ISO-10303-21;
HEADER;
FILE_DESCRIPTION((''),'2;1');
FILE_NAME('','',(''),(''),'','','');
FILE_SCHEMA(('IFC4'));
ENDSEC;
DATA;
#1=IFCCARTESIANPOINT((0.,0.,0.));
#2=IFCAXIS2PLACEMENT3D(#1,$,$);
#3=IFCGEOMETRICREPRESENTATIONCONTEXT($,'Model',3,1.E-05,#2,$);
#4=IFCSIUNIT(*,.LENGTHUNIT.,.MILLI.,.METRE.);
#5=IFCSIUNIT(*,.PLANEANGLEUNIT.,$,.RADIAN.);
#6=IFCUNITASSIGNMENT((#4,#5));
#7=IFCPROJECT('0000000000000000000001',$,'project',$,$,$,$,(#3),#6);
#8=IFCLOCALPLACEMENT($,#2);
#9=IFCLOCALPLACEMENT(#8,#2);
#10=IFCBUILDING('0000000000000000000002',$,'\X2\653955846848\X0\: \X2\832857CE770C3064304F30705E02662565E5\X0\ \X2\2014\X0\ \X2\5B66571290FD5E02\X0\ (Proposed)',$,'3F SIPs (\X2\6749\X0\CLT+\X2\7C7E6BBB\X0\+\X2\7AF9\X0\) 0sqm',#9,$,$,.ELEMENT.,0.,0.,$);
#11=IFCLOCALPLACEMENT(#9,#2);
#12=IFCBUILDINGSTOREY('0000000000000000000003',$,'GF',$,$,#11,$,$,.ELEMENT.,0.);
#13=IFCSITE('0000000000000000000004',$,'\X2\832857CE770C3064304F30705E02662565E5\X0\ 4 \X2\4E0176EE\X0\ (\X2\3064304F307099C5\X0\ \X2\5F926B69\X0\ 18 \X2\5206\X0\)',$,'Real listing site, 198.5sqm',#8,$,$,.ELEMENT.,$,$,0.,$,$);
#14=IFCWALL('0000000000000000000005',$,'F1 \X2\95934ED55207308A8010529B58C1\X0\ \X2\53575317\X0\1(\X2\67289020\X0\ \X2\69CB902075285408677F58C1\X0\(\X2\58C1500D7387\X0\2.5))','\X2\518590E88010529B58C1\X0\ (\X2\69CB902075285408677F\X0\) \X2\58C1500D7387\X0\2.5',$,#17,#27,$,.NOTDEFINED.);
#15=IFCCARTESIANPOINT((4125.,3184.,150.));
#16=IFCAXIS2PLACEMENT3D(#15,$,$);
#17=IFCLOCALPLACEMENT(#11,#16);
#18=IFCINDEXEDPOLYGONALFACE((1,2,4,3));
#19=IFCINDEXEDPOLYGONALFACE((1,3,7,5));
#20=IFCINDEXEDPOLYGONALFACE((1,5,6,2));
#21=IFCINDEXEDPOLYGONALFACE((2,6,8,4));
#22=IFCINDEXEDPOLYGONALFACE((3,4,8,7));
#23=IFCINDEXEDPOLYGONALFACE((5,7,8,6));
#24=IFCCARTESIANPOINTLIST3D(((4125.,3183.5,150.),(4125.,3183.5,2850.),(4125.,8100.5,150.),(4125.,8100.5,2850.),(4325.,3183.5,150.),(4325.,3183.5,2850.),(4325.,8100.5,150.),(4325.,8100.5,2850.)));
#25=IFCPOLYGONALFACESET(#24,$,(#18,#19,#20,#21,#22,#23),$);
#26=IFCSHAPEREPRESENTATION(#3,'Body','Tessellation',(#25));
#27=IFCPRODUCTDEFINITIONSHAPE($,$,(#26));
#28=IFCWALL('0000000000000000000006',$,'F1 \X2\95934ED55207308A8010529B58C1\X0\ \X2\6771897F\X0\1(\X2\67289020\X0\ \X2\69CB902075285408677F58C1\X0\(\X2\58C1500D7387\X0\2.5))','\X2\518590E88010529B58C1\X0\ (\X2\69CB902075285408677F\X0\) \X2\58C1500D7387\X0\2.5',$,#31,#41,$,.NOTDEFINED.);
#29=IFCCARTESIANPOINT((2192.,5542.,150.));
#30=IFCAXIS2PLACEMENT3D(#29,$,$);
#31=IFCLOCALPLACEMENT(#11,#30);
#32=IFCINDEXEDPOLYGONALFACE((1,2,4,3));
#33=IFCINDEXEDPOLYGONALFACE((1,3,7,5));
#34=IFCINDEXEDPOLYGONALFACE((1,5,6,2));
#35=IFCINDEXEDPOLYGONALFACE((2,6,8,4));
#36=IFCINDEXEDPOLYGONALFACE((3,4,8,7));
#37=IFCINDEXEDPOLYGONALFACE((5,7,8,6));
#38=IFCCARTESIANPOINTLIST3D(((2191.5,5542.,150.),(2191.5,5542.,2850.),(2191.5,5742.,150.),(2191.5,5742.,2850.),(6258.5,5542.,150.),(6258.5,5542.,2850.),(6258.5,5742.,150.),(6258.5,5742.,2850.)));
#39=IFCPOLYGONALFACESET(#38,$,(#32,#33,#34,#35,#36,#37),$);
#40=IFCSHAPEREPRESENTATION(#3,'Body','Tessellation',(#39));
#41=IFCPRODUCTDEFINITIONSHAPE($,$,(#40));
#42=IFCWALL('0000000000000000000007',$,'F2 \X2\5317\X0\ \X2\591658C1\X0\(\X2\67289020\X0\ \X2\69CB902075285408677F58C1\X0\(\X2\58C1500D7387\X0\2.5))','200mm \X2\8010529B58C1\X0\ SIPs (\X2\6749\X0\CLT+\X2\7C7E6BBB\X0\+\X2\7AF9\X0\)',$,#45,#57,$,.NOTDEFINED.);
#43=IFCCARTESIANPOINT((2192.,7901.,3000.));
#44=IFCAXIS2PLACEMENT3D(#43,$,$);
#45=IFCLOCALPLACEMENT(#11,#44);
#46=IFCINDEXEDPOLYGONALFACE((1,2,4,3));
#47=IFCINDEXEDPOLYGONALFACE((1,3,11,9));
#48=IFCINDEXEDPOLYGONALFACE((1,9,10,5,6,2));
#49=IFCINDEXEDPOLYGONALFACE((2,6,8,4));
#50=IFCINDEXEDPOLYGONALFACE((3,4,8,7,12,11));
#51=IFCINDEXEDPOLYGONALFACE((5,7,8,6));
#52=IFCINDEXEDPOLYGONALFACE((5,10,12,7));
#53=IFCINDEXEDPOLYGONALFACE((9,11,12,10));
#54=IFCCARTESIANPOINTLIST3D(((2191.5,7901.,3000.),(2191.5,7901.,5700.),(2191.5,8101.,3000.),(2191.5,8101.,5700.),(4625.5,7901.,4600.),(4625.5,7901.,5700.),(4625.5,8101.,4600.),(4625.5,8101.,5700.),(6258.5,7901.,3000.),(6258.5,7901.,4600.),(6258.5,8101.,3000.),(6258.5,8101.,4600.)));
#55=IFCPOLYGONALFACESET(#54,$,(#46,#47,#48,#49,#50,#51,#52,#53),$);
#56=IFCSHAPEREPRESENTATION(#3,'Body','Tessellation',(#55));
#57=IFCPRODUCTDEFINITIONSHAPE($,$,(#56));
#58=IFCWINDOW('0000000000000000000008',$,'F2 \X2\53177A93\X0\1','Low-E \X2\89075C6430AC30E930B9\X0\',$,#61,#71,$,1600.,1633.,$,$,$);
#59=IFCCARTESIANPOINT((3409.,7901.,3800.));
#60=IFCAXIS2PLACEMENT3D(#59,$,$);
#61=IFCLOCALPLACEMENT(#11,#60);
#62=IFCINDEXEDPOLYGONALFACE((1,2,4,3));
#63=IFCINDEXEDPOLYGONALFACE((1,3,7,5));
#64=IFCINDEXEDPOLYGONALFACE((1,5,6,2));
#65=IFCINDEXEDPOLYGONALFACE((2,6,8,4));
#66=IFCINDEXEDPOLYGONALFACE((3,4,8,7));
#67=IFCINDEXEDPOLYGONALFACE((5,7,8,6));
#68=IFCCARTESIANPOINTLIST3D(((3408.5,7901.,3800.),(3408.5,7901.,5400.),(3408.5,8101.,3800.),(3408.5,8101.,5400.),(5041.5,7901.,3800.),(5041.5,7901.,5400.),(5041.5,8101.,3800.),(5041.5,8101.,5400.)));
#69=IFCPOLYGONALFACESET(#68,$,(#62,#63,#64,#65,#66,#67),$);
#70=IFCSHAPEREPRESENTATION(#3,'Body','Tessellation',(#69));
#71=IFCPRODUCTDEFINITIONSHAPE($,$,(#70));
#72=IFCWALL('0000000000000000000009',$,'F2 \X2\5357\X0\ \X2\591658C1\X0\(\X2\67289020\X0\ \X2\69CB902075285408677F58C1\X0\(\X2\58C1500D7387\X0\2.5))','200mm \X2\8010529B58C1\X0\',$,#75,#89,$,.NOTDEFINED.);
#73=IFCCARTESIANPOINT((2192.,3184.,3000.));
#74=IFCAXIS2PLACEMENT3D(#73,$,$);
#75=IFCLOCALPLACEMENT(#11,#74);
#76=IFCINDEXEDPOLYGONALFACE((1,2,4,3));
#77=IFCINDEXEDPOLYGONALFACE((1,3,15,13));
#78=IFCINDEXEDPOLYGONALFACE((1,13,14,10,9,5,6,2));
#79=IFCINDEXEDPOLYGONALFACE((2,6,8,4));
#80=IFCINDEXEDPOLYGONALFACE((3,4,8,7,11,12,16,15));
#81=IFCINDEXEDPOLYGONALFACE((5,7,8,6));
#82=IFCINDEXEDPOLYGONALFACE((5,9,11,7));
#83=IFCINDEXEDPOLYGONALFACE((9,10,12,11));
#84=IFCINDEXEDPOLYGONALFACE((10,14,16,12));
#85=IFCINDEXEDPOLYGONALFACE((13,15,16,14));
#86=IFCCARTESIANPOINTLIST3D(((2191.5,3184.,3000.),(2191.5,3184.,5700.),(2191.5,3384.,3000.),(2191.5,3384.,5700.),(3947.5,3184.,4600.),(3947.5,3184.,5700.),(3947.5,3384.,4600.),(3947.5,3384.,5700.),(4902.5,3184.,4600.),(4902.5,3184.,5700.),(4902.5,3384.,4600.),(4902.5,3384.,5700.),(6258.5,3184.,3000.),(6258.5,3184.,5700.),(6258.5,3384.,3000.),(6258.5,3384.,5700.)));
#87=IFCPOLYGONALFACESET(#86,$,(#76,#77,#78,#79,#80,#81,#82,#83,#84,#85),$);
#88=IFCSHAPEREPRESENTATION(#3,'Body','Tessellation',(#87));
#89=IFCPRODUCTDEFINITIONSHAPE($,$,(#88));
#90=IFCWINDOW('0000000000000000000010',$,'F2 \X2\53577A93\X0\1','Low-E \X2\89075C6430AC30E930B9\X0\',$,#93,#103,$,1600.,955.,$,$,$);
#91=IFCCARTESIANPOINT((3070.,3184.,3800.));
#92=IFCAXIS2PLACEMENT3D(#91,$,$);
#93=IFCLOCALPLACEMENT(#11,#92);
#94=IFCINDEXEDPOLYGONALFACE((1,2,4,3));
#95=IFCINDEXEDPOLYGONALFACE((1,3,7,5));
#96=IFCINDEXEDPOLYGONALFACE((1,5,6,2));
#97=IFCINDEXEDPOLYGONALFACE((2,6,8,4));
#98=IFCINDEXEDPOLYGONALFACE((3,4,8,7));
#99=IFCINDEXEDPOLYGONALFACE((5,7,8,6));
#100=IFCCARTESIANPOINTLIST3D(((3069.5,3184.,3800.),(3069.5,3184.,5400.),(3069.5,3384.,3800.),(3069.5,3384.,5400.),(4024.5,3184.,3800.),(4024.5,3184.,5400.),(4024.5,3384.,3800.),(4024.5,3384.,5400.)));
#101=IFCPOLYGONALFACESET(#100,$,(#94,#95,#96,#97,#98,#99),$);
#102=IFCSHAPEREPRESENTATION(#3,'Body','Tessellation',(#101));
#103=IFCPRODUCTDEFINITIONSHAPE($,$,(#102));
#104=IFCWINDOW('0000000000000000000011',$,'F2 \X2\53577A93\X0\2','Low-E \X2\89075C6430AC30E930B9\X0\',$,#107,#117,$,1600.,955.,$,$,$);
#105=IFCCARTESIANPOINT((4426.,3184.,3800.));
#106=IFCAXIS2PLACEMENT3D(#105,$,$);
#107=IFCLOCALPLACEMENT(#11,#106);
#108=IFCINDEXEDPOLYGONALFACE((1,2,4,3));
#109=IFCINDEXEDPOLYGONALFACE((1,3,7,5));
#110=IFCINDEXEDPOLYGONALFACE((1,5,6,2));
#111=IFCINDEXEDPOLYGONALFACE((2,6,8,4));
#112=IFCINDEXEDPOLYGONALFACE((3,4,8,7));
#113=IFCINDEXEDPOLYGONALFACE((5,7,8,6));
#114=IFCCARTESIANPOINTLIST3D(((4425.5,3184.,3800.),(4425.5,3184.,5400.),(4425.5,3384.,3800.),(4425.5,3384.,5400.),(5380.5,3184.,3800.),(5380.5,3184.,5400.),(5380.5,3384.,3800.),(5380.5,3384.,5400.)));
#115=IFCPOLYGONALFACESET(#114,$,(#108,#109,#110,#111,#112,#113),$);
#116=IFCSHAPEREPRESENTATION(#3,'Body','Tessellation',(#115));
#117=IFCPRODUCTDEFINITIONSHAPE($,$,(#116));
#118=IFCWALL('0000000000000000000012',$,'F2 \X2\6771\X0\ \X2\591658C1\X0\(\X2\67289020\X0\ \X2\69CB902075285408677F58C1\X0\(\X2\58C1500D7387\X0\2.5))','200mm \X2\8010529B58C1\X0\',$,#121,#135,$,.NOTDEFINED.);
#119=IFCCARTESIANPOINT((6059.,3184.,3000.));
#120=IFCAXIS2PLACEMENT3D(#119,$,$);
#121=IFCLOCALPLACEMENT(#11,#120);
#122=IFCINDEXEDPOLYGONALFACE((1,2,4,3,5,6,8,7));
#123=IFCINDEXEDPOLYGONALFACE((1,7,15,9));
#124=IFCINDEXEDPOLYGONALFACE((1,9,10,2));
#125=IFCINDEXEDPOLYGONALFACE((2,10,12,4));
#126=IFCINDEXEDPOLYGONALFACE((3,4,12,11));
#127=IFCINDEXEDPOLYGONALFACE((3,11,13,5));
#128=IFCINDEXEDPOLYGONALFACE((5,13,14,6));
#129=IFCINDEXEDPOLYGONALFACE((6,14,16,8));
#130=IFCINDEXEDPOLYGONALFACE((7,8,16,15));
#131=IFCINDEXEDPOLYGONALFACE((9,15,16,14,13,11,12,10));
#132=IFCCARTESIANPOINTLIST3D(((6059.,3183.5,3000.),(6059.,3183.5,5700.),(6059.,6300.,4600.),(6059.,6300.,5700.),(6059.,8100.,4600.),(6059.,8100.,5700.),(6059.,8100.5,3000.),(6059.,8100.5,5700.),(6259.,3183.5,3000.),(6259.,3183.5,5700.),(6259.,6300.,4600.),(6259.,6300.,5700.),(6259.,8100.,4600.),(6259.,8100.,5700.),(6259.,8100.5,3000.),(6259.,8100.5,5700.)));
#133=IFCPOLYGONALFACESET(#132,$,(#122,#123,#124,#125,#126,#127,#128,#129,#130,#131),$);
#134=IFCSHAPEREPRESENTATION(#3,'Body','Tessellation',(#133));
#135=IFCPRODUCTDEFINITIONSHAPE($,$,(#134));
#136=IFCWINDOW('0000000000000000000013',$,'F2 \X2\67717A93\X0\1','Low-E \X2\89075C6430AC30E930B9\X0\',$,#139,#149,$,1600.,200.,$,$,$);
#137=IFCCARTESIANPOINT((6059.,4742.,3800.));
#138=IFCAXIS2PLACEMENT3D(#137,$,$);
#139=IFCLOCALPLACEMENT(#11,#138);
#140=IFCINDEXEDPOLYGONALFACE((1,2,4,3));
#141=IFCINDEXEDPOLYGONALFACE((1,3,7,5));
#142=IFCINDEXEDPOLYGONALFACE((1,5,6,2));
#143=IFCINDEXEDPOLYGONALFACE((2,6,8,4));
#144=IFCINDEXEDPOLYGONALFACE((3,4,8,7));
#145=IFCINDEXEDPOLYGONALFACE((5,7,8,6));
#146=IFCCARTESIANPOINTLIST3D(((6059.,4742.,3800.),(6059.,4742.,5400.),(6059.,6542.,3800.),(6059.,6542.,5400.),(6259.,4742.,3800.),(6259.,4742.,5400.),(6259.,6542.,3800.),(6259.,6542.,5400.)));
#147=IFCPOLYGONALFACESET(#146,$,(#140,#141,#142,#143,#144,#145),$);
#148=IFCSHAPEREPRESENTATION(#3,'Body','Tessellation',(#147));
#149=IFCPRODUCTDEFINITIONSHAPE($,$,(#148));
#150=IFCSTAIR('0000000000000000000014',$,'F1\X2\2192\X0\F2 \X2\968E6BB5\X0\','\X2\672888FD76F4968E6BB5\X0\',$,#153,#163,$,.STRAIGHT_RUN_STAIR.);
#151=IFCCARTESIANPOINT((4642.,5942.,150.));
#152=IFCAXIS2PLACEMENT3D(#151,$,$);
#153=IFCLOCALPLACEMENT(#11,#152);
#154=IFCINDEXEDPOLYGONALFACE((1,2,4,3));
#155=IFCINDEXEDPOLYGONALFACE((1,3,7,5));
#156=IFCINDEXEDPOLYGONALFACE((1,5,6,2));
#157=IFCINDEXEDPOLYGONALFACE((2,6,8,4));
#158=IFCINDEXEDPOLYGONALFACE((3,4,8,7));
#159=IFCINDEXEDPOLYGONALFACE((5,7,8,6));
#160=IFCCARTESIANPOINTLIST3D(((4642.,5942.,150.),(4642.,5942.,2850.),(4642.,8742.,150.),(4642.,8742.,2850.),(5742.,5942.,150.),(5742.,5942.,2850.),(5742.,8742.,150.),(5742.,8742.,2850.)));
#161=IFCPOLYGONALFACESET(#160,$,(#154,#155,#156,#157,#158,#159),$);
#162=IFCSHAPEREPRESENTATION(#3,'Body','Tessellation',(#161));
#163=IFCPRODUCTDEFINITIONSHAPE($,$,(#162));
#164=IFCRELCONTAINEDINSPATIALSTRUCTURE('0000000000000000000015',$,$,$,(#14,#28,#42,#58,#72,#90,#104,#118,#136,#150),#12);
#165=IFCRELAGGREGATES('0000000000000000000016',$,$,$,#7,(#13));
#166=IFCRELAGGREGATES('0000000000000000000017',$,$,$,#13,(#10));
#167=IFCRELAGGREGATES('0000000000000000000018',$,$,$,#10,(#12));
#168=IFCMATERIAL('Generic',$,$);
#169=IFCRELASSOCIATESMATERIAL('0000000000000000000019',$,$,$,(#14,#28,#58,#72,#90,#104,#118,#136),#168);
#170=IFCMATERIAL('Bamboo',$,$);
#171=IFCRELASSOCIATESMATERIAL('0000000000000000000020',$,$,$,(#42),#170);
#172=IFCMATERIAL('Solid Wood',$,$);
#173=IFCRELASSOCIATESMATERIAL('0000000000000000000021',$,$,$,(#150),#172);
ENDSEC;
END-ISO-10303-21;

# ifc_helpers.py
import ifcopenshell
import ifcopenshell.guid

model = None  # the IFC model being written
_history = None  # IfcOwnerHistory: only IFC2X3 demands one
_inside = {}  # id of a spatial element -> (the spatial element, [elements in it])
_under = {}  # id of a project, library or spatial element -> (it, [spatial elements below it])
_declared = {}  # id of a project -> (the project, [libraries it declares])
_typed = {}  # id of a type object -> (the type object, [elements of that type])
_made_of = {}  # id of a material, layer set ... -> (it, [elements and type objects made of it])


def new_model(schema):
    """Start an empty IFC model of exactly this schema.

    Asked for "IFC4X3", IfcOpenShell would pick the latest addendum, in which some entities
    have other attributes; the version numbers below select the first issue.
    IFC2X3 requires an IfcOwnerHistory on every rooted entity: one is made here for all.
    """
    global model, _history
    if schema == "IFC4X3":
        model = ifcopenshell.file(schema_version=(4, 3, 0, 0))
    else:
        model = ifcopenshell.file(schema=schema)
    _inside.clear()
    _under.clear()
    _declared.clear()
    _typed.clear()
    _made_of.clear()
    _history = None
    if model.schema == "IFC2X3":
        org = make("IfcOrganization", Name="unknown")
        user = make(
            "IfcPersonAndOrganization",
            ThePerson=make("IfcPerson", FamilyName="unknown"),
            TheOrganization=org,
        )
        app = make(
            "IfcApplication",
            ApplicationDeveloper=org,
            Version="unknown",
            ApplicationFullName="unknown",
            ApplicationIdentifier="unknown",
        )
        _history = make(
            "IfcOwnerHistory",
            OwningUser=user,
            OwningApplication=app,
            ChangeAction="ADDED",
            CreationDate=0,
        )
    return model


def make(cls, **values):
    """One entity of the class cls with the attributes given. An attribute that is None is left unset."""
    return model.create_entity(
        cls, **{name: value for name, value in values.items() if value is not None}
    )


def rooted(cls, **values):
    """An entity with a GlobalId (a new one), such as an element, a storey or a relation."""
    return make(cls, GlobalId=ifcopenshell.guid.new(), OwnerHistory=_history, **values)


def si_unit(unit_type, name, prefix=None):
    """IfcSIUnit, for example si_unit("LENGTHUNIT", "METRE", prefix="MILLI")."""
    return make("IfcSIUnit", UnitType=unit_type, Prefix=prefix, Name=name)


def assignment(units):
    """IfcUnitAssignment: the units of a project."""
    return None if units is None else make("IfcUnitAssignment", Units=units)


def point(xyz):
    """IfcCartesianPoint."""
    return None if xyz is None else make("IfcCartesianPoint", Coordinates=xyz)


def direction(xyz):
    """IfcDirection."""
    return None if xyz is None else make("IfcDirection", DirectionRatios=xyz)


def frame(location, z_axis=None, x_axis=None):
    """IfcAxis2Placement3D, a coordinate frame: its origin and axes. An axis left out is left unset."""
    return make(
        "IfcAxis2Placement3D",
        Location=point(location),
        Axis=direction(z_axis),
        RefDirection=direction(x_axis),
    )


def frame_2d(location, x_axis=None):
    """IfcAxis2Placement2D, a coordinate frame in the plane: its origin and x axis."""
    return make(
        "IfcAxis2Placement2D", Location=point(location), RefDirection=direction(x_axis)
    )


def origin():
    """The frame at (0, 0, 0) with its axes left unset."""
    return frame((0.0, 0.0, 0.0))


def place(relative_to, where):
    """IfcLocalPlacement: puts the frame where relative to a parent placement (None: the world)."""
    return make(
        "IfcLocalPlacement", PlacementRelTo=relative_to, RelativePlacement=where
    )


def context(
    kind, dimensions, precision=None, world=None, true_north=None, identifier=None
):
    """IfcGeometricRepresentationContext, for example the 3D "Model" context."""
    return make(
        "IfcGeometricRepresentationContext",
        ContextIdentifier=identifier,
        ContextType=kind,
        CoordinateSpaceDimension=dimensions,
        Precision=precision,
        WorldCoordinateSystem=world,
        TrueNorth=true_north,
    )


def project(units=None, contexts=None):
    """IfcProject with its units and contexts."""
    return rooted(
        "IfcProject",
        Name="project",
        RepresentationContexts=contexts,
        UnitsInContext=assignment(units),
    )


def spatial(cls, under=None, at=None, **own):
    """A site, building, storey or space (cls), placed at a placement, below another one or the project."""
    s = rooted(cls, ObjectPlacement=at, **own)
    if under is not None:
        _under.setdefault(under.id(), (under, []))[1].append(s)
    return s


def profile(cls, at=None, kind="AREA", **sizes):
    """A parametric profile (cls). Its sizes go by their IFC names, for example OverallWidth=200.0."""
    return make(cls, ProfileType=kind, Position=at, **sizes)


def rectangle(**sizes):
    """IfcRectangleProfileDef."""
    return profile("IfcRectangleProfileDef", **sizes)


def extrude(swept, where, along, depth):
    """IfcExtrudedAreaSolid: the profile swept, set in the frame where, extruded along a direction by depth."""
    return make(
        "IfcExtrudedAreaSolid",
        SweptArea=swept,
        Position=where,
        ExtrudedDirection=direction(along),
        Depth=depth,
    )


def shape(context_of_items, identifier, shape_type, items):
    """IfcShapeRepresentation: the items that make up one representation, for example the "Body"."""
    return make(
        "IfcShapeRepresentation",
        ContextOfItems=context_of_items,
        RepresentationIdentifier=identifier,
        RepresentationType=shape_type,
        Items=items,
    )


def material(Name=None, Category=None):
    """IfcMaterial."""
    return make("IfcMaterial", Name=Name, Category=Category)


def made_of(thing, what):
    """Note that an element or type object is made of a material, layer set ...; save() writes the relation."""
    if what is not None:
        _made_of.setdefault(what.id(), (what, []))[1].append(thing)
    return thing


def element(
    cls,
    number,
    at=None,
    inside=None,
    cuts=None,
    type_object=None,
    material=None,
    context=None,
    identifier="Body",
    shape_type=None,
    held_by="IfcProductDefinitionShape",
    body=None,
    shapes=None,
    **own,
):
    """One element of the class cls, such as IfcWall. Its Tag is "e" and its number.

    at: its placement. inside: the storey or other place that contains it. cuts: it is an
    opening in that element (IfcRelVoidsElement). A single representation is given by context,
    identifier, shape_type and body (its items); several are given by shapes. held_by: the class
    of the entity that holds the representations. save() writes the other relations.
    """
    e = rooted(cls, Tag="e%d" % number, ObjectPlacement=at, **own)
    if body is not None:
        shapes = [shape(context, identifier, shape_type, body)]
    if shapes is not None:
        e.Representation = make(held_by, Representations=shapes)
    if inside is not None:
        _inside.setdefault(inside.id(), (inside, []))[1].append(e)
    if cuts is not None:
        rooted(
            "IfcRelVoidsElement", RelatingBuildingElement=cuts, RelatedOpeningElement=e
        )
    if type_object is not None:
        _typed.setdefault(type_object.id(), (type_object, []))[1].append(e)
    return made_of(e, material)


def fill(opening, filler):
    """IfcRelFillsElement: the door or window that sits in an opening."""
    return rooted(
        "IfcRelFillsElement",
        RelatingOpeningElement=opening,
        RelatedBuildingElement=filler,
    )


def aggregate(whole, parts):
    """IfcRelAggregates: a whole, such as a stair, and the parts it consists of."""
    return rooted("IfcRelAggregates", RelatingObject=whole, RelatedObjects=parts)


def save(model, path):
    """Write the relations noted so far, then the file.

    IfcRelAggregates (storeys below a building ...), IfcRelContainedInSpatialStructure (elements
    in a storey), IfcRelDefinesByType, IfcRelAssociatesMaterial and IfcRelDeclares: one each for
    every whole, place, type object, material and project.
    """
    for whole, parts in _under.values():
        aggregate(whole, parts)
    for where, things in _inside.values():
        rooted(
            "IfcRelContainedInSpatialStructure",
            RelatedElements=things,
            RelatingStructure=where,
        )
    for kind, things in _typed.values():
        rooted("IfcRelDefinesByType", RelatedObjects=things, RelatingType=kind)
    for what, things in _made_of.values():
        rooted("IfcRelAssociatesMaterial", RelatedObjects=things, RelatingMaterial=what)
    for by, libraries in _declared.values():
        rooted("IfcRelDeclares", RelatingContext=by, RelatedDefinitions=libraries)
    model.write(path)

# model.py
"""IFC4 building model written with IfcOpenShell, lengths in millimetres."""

from ifc_helpers import new_model, si_unit, frame, frame_2d, origin, place, context, project, spatial, rectangle, extrude, material, element, fill, save


model = new_model("IFC4")

# Units and contexts
model_context = context("Model", 3, precision=1e-05, world=origin())
ifc_project = project(units=[si_unit("LENGTHUNIT", "METRE", prefix="MILLI"), si_unit("PLANEANGLEUNIT", "RADIAN")], contexts=[model_context])

# Site, building, storey
site_placement = place(None, origin())
site = spatial("IfcSite", under=ifc_project, at=site_placement, Name="茨城県つくば市春日 4 丁目 (つくば駅 徒歩 18 分)", ObjectType="Real listing site, 198.5sqm", CompositionType="ELEMENT", RefElevation=0.0)
building_placement = place(site_placement, origin())
building = spatial("IfcBuilding", under=site, at=building_placement, Name="改善案: 茨城県つくば市春日 — 学園都市 (Proposed)", ObjectType="3F SIPs (杉CLT+籾殻+竹) 0sqm", CompositionType="ELEMENT", ElevationOfRefHeight=0.0, ElevationOfTerrain=0.0)
storey_placement = place(building_placement, origin())
storey = spatial("IfcBuildingStorey", under=building, at=storey_placement, Name="GF", CompositionType="ELEMENT", Elevation=0.0)

# Shared definitions
ifc_material_1 = material(Name="Generic")

# Shared definitions
ifc_material_2 = material(Name="Bamboo")

# Shared definitions
ifc_material_3 = material(Name="Solid Wood")

# Walls
wall_1_placement = place(storey_placement, frame((4125.0, 3184.0, 150.0)))
element("IfcWall", 1, at=wall_1_placement, inside=storey, material=ifc_material_1, Name="F1 間仕切り耐力壁 南北1(木造 構造用合板壁(壁倍率2.5))", Description="内部耐力壁 (構造用合板) 壁倍率2.5", PredefinedType="NOTDEFINED", context=model_context, shape_type="SweptSolid", body=[
    extrude(rectangle(XDim=200.0, YDim=4917.0, at=frame_2d((100.0, 2458.0))), frame((4125.0, 3184.0, 150.0)), (0.0, 0.0, 1.0), 2700.0),
])
wall_2_placement = place(storey_placement, frame((2192.0, 5542.0, 150.0)))
element("IfcWall", 2, at=wall_2_placement, inside=storey, material=ifc_material_1, Name="F1 間仕切り耐力壁 東西1(木造 構造用合板壁(壁倍率2.5))", Description="内部耐力壁 (構造用合板) 壁倍率2.5", PredefinedType="NOTDEFINED", context=model_context, shape_type="SweptSolid", body=[
    extrude(rectangle(XDim=4067.0, YDim=200.0, at=frame_2d((2033.0, 100.0))), frame((2192.0, 5542.0, 150.0)), (0.0, 0.0, 1.0), 2700.0),
])

# Wall, opening, window
wall_3_placement = place(storey_placement, frame((2192.0, 7901.0, 3000.0)))
wall_3 = element("IfcWall", 3, at=wall_3_placement, inside=storey, material=ifc_material_2, Name="F2 北 外壁(木造 構造用合板壁(壁倍率2.5))", Description="200mm 耐力壁 SIPs (杉CLT+籾殻+竹)", PredefinedType="NOTDEFINED", context=model_context, shape_type="SweptSolid", body=[
    extrude(rectangle(XDim=4067.0, YDim=200.0, at=frame_2d((2033.0, 100.0))), frame((2192.0, 7901.0, 3000.0)), (0.0, 0.0, 1.0), 2700.0),
])
opening_1_placement = place(storey_placement, frame((3409.0, 7901.0, 3800.0)))
opening_1 = element("IfcOpeningElement", 4, at=opening_1_placement, cuts=wall_3, PredefinedType="NOTDEFINED", context=model_context, shape_type="SweptSolid", body=[
    extrude(rectangle(XDim=1633.0, YDim=200.0, at=frame_2d((816.0, 100.0))), frame((3409.0, 7901.0, 3800.0)), (0.0, 0.0, 1.0), 1600.0),
])
window_1_placement = place(storey_placement, frame((3409.0, 7901.0, 3800.0)))
window_1 = element("IfcWindow", 5, at=window_1_placement, inside=storey, material=ifc_material_1, Name="F2 北窓1", Description="Low-E 複層ガラス", OverallHeight=1600.0, OverallWidth=1633.0, context=model_context, shape_type="SweptSolid", body=[
    extrude(rectangle(XDim=1633.0, YDim=200.0, at=frame_2d((816.0, 100.0))), frame((3409.0, 7901.0, 3800.0)), (0.0, 0.0, 1.0), 1600.0),
])
fill(opening_1, window_1)

# Wall, openings, windows
wall_4_placement = place(storey_placement, frame((2192.0, 3184.0, 3000.0)))
wall_4 = element("IfcWall", 6, at=wall_4_placement, inside=storey, material=ifc_material_1, Name="F2 南 外壁(木造 構造用合板壁(壁倍率2.5))", Description="200mm 耐力壁", PredefinedType="NOTDEFINED", context=model_context, shape_type="SweptSolid", body=[
    extrude(rectangle(XDim=4067.0, YDim=200.0, at=frame_2d((2033.0, 100.0))), frame((2192.0, 3184.0, 3000.0)), (0.0, 0.0, 1.0), 2700.0),
])
opening_2_placement = place(storey_placement, frame((3070.0, 3184.0, 3800.0)))
opening_2 = element("IfcOpeningElement", 7, at=opening_2_placement, cuts=wall_4, PredefinedType="NOTDEFINED", context=model_context, shape_type="SweptSolid", body=[
    extrude(rectangle(XDim=955.0, YDim=200.0, at=frame_2d((477.0, 100.0))), frame((3070.0, 3184.0, 3800.0)), (0.0, 0.0, 1.0), 1600.0),
])
opening_3_placement = place(storey_placement, frame((4426.0, 3184.0, 3800.0)))
opening_3 = element("IfcOpeningElement", 8, at=opening_3_placement, cuts=wall_4, PredefinedType="NOTDEFINED", context=model_context, shape_type="SweptSolid", body=[
    extrude(rectangle(XDim=955.0, YDim=200.0, at=frame_2d((477.0, 100.0))), frame((4426.0, 3184.0, 3800.0)), (0.0, 0.0, 1.0), 1600.0),
])
window_2_placement = place(storey_placement, frame((3070.0, 3184.0, 3800.0)))
window_2 = element("IfcWindow", 9, at=window_2_placement, inside=storey, material=ifc_material_1, Name="F2 南窓1", Description="Low-E 複層ガラス", OverallHeight=1600.0, OverallWidth=955.0, context=model_context, shape_type="SweptSolid", body=[
    extrude(rectangle(XDim=955.0, YDim=200.0, at=frame_2d((477.0, 100.0))), frame((3070.0, 3184.0, 3800.0)), (0.0, 0.0, 1.0), 1600.0),
])
fill(opening_2, window_2)
window_3_placement = place(storey_placement, frame((4426.0, 3184.0, 3800.0)))
window_3 = element("IfcWindow", 10, at=window_3_placement, inside=storey, material=ifc_material_1, Name="F2 南窓2", Description="Low-E 複層ガラス", OverallHeight=1600.0, OverallWidth=955.0, context=model_context, shape_type="SweptSolid", body=[
    extrude(rectangle(XDim=955.0, YDim=200.0, at=frame_2d((477.0, 100.0))), frame((4426.0, 3184.0, 3800.0)), (0.0, 0.0, 1.0), 1600.0),
])
fill(opening_3, window_3)

# Wall, opening, window
wall_5_placement = place(storey_placement, frame((6059.0, 3184.0, 3000.0)))
wall_5 = element("IfcWall", 11, at=wall_5_placement, inside=storey, material=ifc_material_1, Name="F2 東 外壁(木造 構造用合板壁(壁倍率2.5))", Description="200mm 耐力壁", PredefinedType="NOTDEFINED", context=model_context, shape_type="SweptSolid", body=[
    extrude(rectangle(XDim=200.0, YDim=4917.0, at=frame_2d((100.0, 2458.0))), frame((6059.0, 3184.0, 3000.0)), (0.0, 0.0, 1.0), 2700.0),
])
opening_4_placement = place(storey_placement, frame((6059.0, 4742.0, 3800.0)))
opening_4 = element("IfcOpeningElement", 12, at=opening_4_placement, cuts=wall_5, PredefinedType="NOTDEFINED", context=model_context, shape_type="SweptSolid", body=[
    extrude(rectangle(XDim=200.0, YDim=1800.0, at=frame_2d((100.0, 900.0))), frame((6059.0, 4742.0, 3800.0)), (0.0, 0.0, 1.0), 1600.0),
])
window_4_placement = place(storey_placement, frame((6059.0, 4742.0, 3800.0)))
window_4 = element("IfcWindow", 13, at=window_4_placement, inside=storey, material=ifc_material_1, Name="F2 東窓1", Description="Low-E 複層ガラス", OverallHeight=1600.0, OverallWidth=200.0, context=model_context, shape_type="SweptSolid", body=[
    extrude(rectangle(XDim=200.0, YDim=1800.0, at=frame_2d((100.0, 900.0))), frame((6059.0, 4742.0, 3800.0)), (0.0, 0.0, 1.0), 1600.0),
])
fill(opening_4, window_4)

# Stair
stair_placement = place(storey_placement, frame((4642.0, 5942.0, 150.0)))
element("IfcStair", 14, at=stair_placement, inside=storey, material=ifc_material_3, Name="F1→F2 階段", Description="木製直階段", PredefinedType="STRAIGHT_RUN_STAIR", context=model_context, shape_type="SweptSolid", body=[
    extrude(rectangle(XDim=1100.0, YDim=2800.0, at=frame_2d((550.0, 1400.0))), frame((4642.0, 5942.0, 150.0)), (0.0, 0.0, 1.0), 2700.0),
])

save(model, "model.ifc")
